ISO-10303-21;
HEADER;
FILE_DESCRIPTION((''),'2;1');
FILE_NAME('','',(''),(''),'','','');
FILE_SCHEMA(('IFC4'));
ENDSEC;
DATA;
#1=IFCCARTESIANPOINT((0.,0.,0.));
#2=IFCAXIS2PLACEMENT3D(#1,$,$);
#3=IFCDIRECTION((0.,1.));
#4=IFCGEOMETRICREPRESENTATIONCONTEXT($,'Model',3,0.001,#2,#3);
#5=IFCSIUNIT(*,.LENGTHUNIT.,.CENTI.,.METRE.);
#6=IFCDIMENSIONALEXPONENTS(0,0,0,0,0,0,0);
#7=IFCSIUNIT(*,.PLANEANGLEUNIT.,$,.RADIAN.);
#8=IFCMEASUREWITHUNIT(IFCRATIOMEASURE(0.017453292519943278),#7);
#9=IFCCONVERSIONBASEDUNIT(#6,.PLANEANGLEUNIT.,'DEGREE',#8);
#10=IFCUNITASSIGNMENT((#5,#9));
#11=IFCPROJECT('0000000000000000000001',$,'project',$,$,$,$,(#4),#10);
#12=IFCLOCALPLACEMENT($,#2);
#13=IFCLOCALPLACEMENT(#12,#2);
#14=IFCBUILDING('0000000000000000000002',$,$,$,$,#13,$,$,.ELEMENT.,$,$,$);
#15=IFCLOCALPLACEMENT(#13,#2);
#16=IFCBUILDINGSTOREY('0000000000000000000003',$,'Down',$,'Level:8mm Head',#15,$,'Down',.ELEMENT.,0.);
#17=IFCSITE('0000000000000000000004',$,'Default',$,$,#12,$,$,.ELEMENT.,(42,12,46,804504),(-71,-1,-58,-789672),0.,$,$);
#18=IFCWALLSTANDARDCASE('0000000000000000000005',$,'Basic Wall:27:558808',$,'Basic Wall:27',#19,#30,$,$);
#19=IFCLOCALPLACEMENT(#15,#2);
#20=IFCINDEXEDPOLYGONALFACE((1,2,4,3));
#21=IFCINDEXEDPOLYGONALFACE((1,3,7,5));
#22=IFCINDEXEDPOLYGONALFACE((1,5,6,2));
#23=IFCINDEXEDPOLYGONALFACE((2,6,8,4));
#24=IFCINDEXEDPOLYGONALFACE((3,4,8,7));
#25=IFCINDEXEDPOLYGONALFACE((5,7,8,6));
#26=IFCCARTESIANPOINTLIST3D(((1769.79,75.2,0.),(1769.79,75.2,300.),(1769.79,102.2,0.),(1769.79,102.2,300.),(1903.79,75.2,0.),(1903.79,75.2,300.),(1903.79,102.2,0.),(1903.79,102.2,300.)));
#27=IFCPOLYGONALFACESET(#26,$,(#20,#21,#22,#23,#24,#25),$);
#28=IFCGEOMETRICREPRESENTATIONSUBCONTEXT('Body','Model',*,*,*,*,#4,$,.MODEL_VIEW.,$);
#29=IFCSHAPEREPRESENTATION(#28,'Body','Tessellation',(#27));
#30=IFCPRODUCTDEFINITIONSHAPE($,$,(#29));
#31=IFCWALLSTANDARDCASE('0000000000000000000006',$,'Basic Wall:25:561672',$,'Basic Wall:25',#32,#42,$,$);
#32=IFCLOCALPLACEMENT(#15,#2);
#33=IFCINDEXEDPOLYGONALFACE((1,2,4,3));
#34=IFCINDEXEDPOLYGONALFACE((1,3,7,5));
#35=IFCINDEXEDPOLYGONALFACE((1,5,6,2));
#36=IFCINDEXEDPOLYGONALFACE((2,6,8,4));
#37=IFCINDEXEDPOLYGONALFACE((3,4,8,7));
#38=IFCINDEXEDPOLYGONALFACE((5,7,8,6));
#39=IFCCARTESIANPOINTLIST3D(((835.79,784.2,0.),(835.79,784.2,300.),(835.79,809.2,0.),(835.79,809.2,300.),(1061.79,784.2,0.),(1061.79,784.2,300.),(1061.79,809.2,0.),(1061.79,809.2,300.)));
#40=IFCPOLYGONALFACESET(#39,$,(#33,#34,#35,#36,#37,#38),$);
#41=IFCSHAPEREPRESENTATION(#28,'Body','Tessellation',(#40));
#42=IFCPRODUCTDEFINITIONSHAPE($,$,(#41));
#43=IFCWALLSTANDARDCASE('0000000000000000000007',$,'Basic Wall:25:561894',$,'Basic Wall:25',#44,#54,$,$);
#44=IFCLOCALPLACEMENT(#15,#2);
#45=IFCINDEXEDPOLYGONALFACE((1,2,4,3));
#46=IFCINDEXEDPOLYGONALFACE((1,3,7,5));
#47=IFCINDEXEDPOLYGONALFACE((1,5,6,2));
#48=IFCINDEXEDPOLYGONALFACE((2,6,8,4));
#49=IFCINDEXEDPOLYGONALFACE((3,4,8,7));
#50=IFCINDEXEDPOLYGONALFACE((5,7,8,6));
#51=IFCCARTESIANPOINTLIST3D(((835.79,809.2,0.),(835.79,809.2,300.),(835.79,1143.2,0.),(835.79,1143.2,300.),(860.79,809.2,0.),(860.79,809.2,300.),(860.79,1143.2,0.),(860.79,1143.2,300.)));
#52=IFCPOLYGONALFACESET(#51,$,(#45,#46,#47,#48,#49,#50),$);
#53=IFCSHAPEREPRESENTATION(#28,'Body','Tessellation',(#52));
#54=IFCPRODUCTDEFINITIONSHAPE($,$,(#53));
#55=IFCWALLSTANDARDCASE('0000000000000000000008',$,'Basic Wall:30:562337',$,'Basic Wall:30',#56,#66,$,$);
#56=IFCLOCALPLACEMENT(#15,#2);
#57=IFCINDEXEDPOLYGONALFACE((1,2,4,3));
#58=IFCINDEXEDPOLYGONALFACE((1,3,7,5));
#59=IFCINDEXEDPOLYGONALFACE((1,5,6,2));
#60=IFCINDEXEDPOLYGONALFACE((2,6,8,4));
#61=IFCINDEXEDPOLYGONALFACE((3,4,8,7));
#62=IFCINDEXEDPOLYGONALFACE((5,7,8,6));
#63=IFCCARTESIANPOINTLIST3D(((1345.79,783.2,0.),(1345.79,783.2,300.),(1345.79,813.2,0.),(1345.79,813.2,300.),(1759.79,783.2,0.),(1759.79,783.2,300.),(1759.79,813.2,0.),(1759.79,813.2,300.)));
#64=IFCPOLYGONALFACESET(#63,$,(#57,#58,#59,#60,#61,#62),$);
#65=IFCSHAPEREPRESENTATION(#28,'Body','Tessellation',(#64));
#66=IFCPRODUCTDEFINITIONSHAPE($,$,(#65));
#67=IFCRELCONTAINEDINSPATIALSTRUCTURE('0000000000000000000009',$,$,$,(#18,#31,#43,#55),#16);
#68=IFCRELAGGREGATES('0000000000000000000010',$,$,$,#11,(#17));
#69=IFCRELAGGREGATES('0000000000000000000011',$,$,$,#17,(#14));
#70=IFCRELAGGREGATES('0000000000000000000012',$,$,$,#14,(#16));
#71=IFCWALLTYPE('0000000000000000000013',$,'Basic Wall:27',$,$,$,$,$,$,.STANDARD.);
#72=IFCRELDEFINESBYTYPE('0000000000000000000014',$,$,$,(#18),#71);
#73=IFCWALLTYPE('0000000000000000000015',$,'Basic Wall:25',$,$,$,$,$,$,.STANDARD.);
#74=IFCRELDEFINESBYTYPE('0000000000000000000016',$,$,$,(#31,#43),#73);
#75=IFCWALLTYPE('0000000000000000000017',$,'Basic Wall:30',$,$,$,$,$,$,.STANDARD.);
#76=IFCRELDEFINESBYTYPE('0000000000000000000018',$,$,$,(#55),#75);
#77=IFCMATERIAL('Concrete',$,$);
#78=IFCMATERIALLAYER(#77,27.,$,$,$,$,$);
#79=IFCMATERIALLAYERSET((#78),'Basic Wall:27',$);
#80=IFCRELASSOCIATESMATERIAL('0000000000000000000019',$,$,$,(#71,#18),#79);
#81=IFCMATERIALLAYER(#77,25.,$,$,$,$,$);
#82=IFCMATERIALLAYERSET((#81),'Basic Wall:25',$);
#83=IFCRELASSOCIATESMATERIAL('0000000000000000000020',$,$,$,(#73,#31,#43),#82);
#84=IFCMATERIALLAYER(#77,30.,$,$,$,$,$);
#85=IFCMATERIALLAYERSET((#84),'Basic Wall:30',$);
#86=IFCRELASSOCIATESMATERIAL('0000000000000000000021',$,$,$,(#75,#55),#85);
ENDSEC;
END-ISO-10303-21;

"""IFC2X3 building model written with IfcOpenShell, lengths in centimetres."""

from ifc_helpers import new_model, entity, si_unit, converted_unit, direction, frame, frame_2d, origin, place, context, subcontext, project, spatial, rectangle, extrude, material, layer, layer_set, layer_usage, type_object, element, save


model = new_model("IFC2X3")

# Units and contexts
model_context = context("Model", 3, precision=0.001, world=origin(), true_north=direction((0.0, 1.0)))
body_context = subcontext(model_context, "Body", "Model", "MODEL_VIEW")
ifc_project = project(units=[si_unit("LENGTHUNIT", "METRE", prefix="CENTI"), converted_unit("PLANEANGLEUNIT", "DEGREE", entity("IfcRatioMeasure", 0.017453292519943278), si_unit("PLANEANGLEUNIT", "RADIAN"), dimensions=[0, 0, 0, 0, 0, 0, 0])], contexts=[model_context])

# Site, building, storey
site_placement = place(None, origin())
site = spatial("IfcSite", under=ifc_project, at=site_placement, Name="Default", CompositionType="ELEMENT", RefLatitude=(42, 12, 46, 804504), RefLongitude=(-71, -1, -58, -789672), RefElevation=0.0)
building_placement = place(site_placement, origin())
building = spatial("IfcBuilding", under=site, at=building_placement, CompositionType="ELEMENT")
storey_placement = place(building_placement, origin())
storey = spatial("IfcBuildingStorey", under=building, at=storey_placement, Name="Down", ObjectType="Level:8mm Head", LongName="Down", CompositionType="ELEMENT", Elevation=0.0)

# Walls
ifc_material = material(Name="Concrete")
ifc_layer_1 = layer(ifc_material, 27.0)
ifc_layer_set_1 = layer_set([ifc_layer_1], Name="Basic Wall:27")
ifc_layer_usage_1 = layer_usage(ifc_layer_set_1, "AXIS2", "POSITIVE", -13.5)
wall_type_1 = type_object("IfcWallType", Name="Basic Wall:27", PredefinedType="STANDARD", material=ifc_layer_set_1)
wall_1_placement = place(storey_placement, frame((1769.79, 88.7, 0.0)))
element("IfcWallStandardCase", 1, at=wall_1_placement, inside=storey, type_object=wall_type_1, material=ifc_layer_usage_1, Name="Basic Wall:27:558808", ObjectType="Basic Wall:27", context=body_context, shape_type="SweptSolid", body=[
    extrude(rectangle(XDim=134.0, YDim=27.0, at=frame_2d((67.0, 0.0), x_axis=(-1.0, 0.0))), origin(), (0.0, 0.0, 1.0), 300.0),
])
ifc_layer_2 = layer(ifc_material, 25.0)
ifc_layer_set_2 = layer_set([ifc_layer_2], Name="Basic Wall:25")
ifc_layer_usage_2 = layer_usage(ifc_layer_set_2, "AXIS2", "POSITIVE", -12.5)
wall_type_2 = type_object("IfcWallType", Name="Basic Wall:25", PredefinedType="STANDARD", material=ifc_layer_set_2)
wall_2_placement = place(storey_placement, frame((1061.79, 796.7, 0.0), z_axis=(0.0, 0.0, 1.0), x_axis=(-1.0, 0.0, 0.0)))
element("IfcWallStandardCase", 2, at=wall_2_placement, inside=storey, type_object=wall_type_2, material=ifc_layer_usage_2, Name="Basic Wall:25:561672", ObjectType="Basic Wall:25", context=body_context, shape_type="SweptSolid", body=[
    extrude(rectangle(XDim=226.0, YDim=25.0, at=frame_2d((113.0, 0.0), x_axis=(-1.0, 0.0))), origin(), (0.0, 0.0, 1.0), 300.0),
])
ifc_layer_usage_3 = layer_usage(ifc_layer_set_2, "AXIS2", "NEGATIVE", 12.5)
wall_3_placement = place(storey_placement, frame((848.29, 809.2, 0.0), z_axis=(0.0, 0.0, 1.0), x_axis=(0.0, 1.0, 0.0)))
element("IfcWallStandardCase", 3, at=wall_3_placement, inside=storey, type_object=wall_type_2, material=ifc_layer_usage_3, Name="Basic Wall:25:561894", ObjectType="Basic Wall:25", context=body_context, shape_type="SweptSolid", body=[
    extrude(rectangle(XDim=334.0, YDim=25.0, at=frame_2d((167.0, 0.0), x_axis=(-1.0, 0.0))), origin(), (0.0, 0.0, 1.0), 300.0),
])
ifc_layer_3 = layer(ifc_material, 30.0)
ifc_layer_set_3 = layer_set([ifc_layer_3], Name="Basic Wall:30")
ifc_layer_usage_4 = layer_usage(ifc_layer_set_3, "AXIS2", "NEGATIVE", 15.0)
wall_type_3 = type_object("IfcWallType", Name="Basic Wall:30", PredefinedType="STANDARD", material=ifc_layer_set_3)
wall_4_placement = place(storey_placement, frame((1759.79, 798.2, 0.0), z_axis=(0.0, 0.0, 1.0), x_axis=(-1.0, 0.0, 0.0)))
element("IfcWallStandardCase", 4, at=wall_4_placement, inside=storey, type_object=wall_type_3, material=ifc_layer_usage_4, Name="Basic Wall:30:562337", ObjectType="Basic Wall:30", context=body_context, shape_type="SweptSolid", body=[
    extrude(rectangle(XDim=414.0, YDim=30.0, at=frame_2d((207.0, 0.0), x_axis=(-1.0, 0.0))), origin(), (0.0, 0.0, 1.0), 300.0),
])

save(model, "model.ifc")
